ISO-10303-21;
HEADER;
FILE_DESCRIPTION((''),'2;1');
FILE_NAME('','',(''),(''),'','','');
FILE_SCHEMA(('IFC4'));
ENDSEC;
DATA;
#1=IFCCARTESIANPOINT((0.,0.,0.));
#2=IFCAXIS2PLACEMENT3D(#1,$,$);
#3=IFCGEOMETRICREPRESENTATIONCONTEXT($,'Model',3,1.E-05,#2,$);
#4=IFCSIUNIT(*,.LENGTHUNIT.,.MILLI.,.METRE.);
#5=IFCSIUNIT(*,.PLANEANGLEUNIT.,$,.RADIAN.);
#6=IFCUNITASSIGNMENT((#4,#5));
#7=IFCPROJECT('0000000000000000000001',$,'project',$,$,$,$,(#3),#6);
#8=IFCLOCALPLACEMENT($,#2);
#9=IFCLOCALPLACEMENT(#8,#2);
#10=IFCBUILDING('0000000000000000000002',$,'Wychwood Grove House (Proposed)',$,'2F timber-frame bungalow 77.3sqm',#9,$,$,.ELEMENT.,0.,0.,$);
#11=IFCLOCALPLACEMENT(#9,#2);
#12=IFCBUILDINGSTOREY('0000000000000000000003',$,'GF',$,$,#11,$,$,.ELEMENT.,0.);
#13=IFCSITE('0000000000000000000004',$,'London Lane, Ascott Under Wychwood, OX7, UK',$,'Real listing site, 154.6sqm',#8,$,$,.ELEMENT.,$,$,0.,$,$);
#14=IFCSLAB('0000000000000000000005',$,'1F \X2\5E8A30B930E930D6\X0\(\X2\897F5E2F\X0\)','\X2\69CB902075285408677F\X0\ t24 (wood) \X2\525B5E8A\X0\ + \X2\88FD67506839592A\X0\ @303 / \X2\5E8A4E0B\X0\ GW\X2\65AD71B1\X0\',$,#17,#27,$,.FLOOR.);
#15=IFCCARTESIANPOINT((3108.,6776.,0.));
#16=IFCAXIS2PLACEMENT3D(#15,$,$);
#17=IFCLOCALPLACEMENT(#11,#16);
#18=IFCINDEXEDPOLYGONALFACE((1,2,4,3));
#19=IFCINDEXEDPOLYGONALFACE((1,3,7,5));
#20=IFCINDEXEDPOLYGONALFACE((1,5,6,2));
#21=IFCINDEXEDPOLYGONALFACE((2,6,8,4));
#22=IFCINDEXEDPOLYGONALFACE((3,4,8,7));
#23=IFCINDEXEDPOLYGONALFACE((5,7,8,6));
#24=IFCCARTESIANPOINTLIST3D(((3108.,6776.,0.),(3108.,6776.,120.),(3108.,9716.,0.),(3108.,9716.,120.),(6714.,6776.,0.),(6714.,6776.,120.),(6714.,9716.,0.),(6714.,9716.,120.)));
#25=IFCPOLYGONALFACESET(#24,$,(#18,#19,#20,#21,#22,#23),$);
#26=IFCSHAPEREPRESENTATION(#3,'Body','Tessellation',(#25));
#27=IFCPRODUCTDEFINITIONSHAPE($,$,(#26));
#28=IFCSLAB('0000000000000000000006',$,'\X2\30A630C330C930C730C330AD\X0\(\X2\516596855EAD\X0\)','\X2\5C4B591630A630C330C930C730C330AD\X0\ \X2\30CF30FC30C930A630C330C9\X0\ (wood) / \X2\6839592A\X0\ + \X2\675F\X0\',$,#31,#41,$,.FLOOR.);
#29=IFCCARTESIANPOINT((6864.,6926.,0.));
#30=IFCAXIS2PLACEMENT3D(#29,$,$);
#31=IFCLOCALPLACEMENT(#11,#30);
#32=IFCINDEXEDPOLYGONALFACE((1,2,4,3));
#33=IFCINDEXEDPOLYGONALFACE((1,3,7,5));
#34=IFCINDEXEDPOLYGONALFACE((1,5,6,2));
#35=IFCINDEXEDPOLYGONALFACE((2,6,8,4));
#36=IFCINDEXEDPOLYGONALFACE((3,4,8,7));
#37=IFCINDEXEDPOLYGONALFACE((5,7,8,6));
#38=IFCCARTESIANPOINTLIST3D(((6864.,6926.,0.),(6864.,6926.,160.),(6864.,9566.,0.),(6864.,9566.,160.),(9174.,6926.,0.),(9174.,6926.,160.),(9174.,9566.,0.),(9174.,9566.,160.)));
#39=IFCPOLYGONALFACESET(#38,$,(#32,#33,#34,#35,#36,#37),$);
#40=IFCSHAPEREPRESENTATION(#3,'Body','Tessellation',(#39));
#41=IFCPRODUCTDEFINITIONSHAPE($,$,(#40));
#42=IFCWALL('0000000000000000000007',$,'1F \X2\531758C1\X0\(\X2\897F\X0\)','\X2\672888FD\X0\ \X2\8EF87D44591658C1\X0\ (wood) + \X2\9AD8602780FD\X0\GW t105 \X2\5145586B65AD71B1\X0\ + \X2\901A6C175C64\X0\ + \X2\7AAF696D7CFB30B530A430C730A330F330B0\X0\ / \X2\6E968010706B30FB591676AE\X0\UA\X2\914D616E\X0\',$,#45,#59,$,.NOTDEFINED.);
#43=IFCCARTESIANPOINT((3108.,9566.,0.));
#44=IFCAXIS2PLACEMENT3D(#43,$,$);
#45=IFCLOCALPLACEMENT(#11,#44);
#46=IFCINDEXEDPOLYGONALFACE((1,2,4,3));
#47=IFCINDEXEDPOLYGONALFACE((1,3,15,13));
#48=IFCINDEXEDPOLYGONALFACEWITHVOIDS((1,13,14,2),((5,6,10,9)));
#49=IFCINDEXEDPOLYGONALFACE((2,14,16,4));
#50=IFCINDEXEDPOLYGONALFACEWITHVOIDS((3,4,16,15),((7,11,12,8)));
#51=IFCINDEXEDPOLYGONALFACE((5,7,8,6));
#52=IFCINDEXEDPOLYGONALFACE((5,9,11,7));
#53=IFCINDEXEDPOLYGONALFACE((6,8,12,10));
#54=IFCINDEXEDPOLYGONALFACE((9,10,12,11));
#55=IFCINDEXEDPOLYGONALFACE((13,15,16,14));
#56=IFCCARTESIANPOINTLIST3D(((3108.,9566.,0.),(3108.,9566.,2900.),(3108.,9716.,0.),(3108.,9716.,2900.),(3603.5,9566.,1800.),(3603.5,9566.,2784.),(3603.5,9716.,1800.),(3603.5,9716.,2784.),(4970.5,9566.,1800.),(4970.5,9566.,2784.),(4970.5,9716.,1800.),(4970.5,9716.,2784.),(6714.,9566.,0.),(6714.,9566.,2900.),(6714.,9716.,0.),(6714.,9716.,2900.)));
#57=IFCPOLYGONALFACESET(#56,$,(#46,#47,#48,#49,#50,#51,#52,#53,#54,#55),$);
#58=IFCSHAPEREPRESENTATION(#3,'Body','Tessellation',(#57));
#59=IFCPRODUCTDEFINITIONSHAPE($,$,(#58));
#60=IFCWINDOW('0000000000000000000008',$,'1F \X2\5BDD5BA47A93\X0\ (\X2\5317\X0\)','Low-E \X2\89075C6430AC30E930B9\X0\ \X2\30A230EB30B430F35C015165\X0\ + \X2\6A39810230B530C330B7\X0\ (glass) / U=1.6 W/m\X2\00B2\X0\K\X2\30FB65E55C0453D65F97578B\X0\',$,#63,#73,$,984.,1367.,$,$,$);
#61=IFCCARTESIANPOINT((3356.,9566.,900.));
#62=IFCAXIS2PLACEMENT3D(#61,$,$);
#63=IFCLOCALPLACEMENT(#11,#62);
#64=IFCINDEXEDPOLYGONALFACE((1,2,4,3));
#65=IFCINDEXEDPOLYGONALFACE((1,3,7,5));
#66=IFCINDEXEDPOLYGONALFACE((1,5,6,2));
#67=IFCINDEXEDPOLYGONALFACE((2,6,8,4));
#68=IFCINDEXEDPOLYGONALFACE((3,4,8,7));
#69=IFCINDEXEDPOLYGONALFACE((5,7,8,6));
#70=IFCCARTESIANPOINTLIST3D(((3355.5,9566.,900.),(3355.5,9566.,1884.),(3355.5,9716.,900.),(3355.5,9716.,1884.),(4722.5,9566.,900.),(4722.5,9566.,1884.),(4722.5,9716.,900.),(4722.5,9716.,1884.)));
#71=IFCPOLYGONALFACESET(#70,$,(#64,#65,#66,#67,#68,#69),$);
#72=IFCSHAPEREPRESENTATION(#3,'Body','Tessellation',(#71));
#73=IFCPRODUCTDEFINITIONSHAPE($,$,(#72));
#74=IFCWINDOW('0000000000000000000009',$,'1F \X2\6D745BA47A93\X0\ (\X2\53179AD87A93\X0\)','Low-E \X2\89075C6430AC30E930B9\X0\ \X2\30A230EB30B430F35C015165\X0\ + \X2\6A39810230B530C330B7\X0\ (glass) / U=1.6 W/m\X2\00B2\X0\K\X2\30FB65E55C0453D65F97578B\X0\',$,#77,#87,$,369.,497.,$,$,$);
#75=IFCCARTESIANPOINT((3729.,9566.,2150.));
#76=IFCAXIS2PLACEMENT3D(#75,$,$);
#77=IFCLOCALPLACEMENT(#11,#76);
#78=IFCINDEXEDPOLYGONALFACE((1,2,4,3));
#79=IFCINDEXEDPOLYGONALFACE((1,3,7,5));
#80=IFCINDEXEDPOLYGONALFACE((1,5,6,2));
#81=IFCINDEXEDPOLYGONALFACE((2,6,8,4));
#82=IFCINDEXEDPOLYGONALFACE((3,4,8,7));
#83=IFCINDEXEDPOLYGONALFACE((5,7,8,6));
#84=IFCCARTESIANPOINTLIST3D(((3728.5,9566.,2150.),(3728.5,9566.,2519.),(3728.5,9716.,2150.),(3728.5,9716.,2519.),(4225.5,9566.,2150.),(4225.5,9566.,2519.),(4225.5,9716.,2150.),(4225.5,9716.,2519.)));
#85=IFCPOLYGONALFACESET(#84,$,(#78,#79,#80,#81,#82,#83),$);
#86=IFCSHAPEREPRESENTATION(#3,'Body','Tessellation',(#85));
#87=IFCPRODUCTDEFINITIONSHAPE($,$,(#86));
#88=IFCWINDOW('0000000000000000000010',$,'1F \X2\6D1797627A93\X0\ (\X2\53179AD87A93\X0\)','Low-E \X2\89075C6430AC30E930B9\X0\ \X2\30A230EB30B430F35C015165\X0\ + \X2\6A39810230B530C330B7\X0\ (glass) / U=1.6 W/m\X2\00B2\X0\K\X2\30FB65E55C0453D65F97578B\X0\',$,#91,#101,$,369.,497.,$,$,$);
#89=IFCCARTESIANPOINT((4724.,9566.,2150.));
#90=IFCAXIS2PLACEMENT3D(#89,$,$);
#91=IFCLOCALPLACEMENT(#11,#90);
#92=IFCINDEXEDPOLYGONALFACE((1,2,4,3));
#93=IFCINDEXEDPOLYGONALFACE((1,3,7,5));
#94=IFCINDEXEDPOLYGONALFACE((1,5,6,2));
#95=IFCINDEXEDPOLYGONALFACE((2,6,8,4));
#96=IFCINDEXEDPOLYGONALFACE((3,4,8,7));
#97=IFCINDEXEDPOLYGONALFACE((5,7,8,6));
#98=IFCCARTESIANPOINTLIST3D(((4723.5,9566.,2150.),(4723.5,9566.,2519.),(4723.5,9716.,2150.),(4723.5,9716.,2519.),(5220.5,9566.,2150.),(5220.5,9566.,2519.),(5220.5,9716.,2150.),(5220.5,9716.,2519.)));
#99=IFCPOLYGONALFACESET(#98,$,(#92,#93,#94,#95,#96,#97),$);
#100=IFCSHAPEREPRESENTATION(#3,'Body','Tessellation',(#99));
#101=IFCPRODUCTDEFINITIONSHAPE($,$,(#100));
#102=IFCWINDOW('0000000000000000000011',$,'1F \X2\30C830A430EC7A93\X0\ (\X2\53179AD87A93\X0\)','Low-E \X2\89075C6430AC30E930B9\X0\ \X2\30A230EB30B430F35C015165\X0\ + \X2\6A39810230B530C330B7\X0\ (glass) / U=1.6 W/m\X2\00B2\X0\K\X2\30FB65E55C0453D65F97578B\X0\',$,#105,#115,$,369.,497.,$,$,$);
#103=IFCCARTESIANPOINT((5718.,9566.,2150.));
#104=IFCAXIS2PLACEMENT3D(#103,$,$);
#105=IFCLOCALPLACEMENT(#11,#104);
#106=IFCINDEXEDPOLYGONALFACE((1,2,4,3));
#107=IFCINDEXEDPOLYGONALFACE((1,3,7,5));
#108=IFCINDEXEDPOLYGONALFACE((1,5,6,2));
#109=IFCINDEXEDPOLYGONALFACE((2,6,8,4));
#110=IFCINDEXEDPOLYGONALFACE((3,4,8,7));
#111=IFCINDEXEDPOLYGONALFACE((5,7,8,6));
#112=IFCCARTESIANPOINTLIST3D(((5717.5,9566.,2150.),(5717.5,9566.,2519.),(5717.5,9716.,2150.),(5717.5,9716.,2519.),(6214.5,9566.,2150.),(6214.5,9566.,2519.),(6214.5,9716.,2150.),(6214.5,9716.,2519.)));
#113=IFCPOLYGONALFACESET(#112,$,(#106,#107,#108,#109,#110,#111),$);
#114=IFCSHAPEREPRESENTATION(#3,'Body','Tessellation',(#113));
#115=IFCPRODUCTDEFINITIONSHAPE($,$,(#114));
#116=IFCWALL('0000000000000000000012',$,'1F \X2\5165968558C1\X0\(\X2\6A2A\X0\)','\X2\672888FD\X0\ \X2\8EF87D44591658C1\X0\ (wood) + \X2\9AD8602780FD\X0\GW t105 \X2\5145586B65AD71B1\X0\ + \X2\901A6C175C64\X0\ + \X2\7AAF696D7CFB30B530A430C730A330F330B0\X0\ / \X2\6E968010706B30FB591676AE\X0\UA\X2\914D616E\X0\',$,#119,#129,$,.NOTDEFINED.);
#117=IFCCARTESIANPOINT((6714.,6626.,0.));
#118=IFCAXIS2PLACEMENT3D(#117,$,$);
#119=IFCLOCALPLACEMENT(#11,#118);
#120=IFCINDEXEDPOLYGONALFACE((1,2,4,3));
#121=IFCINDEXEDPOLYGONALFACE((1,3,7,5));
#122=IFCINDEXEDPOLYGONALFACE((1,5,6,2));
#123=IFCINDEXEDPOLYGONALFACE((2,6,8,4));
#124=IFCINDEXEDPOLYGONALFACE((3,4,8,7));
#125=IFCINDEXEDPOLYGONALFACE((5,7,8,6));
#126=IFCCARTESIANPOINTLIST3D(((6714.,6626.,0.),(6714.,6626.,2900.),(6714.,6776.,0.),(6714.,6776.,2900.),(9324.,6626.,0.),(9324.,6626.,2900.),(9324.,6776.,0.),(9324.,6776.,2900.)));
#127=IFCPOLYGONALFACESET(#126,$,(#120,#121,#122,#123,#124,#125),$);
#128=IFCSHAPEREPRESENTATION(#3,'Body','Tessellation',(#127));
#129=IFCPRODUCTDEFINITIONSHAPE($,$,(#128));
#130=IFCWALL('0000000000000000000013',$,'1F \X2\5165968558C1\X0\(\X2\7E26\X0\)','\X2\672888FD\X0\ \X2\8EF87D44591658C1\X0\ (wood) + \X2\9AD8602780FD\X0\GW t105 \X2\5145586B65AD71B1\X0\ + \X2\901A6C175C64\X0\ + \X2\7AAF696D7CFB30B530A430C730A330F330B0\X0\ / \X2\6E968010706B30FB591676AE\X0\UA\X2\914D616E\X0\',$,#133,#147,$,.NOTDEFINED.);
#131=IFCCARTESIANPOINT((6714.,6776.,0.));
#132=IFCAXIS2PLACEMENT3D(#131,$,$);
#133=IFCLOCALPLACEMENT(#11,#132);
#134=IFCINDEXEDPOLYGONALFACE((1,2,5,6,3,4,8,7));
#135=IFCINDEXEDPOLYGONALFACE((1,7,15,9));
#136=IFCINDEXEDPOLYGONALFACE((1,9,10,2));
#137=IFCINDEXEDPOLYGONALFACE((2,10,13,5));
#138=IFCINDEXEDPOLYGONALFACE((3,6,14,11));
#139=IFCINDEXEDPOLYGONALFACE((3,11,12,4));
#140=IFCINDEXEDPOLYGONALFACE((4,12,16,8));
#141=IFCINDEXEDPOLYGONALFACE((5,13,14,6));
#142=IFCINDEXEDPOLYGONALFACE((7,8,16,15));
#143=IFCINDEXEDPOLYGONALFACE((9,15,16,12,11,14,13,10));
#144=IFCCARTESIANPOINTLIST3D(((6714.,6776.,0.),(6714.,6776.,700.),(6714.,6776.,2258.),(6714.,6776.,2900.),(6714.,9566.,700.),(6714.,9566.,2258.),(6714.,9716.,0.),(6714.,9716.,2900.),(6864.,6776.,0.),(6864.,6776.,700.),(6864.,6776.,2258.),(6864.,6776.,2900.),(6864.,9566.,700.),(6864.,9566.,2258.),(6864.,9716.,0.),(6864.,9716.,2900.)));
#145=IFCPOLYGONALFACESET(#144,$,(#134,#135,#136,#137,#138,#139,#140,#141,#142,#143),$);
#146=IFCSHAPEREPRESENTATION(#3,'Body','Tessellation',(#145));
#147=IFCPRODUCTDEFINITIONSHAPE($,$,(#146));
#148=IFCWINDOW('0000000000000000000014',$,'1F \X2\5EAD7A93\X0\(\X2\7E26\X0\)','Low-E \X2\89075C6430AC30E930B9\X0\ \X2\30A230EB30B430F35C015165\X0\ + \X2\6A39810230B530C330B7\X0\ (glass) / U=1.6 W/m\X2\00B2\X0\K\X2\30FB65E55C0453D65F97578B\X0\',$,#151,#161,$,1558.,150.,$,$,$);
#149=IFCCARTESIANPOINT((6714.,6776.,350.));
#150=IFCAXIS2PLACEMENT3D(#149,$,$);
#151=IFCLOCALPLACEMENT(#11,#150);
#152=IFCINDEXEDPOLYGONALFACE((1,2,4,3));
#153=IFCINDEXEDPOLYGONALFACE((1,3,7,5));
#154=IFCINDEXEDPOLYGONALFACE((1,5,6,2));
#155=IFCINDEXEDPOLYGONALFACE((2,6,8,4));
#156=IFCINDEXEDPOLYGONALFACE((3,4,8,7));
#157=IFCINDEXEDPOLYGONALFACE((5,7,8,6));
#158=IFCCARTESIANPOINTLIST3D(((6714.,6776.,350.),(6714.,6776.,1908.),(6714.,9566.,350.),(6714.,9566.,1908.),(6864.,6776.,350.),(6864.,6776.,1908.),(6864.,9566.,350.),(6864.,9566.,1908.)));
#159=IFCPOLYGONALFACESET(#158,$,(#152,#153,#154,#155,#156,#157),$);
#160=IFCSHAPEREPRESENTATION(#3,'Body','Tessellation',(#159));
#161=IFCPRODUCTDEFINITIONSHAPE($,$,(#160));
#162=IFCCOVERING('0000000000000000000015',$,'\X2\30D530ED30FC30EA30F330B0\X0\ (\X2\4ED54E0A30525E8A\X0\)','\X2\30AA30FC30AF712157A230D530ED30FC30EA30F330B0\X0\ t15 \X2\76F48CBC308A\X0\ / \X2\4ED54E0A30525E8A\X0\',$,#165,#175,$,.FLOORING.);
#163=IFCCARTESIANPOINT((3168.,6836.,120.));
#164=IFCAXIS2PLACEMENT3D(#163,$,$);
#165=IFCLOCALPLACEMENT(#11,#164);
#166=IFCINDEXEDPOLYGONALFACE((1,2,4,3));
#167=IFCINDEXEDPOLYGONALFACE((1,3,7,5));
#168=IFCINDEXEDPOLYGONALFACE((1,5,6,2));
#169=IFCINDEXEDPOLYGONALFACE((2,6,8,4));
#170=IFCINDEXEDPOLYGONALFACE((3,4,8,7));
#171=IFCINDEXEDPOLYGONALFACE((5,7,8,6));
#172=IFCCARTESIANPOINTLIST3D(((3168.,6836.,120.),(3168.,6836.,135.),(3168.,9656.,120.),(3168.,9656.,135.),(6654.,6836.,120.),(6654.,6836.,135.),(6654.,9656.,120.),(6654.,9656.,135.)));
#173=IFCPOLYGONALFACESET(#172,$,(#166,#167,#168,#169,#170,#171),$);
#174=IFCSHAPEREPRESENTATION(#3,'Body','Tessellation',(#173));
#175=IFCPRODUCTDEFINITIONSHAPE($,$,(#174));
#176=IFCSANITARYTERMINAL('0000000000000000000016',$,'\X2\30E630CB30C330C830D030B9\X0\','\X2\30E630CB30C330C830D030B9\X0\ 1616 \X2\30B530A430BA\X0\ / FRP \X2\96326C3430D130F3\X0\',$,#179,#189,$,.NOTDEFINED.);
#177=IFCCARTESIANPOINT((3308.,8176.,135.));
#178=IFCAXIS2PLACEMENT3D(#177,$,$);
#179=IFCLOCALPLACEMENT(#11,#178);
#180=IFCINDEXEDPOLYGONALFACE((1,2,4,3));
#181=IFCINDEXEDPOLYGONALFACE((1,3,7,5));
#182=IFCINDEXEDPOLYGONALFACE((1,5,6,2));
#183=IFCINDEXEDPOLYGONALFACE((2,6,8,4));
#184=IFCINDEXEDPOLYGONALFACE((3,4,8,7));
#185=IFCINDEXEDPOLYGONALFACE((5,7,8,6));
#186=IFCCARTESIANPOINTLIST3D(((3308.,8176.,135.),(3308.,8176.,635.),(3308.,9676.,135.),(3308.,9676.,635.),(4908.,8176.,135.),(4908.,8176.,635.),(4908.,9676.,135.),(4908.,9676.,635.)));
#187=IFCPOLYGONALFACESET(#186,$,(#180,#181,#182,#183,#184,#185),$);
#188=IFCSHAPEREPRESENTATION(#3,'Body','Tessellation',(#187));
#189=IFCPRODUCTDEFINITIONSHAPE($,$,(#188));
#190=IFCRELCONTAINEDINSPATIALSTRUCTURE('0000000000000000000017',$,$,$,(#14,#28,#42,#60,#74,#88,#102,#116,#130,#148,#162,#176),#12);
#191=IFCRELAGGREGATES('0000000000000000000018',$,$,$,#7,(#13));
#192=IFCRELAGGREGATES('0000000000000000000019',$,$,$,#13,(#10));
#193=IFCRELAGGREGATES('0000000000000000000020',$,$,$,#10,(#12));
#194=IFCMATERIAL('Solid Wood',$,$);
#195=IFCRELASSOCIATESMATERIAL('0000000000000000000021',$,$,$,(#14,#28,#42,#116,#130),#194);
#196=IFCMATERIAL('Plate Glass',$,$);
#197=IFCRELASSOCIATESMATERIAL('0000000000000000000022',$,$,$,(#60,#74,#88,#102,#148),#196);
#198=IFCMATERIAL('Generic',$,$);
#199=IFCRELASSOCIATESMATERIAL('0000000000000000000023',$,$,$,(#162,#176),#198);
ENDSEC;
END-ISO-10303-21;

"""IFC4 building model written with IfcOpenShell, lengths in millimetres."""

from ifc_helpers import new_model, si_unit, frame, frame_2d, origin, place, context, project, spatial, rectangle, extrude, material, element, fill, save


model = new_model("IFC4")

# Units and contexts
model_context = context("Model", 3, precision=1e-05, world=origin())
ifc_project = project(units=[si_unit("LENGTHUNIT", "METRE", prefix="MILLI"), si_unit("PLANEANGLEUNIT", "RADIAN")], contexts=[model_context])

# Site, building, storey
site_placement = place(None, origin())
site = spatial("IfcSite", under=ifc_project, at=site_placement, Name="London Lane, Ascott Under Wychwood, OX7, UK", ObjectType="Real listing site, 154.6sqm", CompositionType="ELEMENT", RefElevation=0.0)
building_placement = place(site_placement, origin())
building = spatial("IfcBuilding", under=site, at=building_placement, Name="Wychwood Grove House (Proposed)", ObjectType="2F timber-frame bungalow 77.3sqm", CompositionType="ELEMENT", ElevationOfRefHeight=0.0, ElevationOfTerrain=0.0)
storey_placement = place(building_placement, origin())
storey = spatial("IfcBuildingStorey", under=building, at=storey_placement, Name="GF", CompositionType="ELEMENT", Elevation=0.0)

# Slabs
ifc_material_1 = material(Name="Solid Wood")
slab_1_placement = place(storey_placement, frame((3108.0, 6776.0, 0.0)))
element("IfcSlab", 1, at=slab_1_placement, inside=storey, material=ifc_material_1, Name="1F 床スラブ(西帯)", Description="構造用合板 t24 (wood) 剛床 + 製材根太 @303 / 床下 GW断熱", PredefinedType="FLOOR", context=model_context, shape_type="SweptSolid", body=[
    extrude(rectangle(XDim=3606.0, YDim=2940.0, at=frame_2d((1803.0, 1470.0))), frame((3108.0, 6776.0, 0.0)), (0.0, 0.0, 1.0), 120.0),
])
slab_2_placement = place(storey_placement, frame((6864.0, 6926.0, 0.0)))
element("IfcSlab", 2, at=slab_2_placement, inside=storey, material=ifc_material_1, Name="ウッドデッキ(入隅庭)", Description="屋外ウッドデッキ ハードウッド (wood) / 根太 + 束", PredefinedType="FLOOR", context=model_context, shape_type="SweptSolid", body=[
    extrude(rectangle(XDim=2310.0, YDim=2640.0, at=frame_2d((1155.0, 1320.0))), frame((6864.0, 6926.0, 0.0)), (0.0, 0.0, 1.0), 160.0),
])

# Wall, openings, windows
wall_1_placement = place(storey_placement, frame((3108.0, 9566.0, 0.0)))
wall_1 = element("IfcWall", 3, at=wall_1_placement, inside=storey, material=ifc_material_1, Name="1F 北壁(西)", Description="木製 軸組外壁 (wood) + 高性能GW t105 充填断熱 + 通気層 + 窯業系サイディング / 準耐火・外皮UA配慮", PredefinedType="NOTDEFINED", context=model_context, shape_type="SweptSolid", body=[
    extrude(rectangle(XDim=3606.0, YDim=150.0, at=frame_2d((1803.0, 75.0))), frame((3108.0, 9566.0, 0.0)), (0.0, 0.0, 1.0), 2900.0),
])
opening_1_placement = place(storey_placement, frame((3356.0, 9566.0, 900.0)))
opening_1 = element("IfcOpeningElement", 4, at=opening_1_placement, cuts=wall_1, PredefinedType="NOTDEFINED", context=model_context, shape_type="SweptSolid", body=[
    extrude(rectangle(XDim=1367.0, YDim=150.0, at=frame_2d((683.0, 75.0))), frame((3356.0, 9566.0, 900.0)), (0.0, 0.0, 1.0), 984.0),
])
opening_2_placement = place(storey_placement, frame((3729.0, 9566.0, 2150.0)))
opening_2 = element("IfcOpeningElement", 5, at=opening_2_placement, cuts=wall_1, PredefinedType="NOTDEFINED", context=model_context, shape_type="SweptSolid", body=[
    extrude(rectangle(XDim=497.0, YDim=150.0, at=frame_2d((248.0, 75.0))), frame((3729.0, 9566.0, 2150.0)), (0.0, 0.0, 1.0), 369.0),
])
opening_3_placement = place(storey_placement, frame((4724.0, 9566.0, 2150.0)))
opening_3 = element("IfcOpeningElement", 6, at=opening_3_placement, cuts=wall_1, PredefinedType="NOTDEFINED", context=model_context, shape_type="SweptSolid", body=[
    extrude(rectangle(XDim=497.0, YDim=150.0, at=frame_2d((248.0, 75.0))), frame((4724.0, 9566.0, 2150.0)), (0.0, 0.0, 1.0), 369.0),
])
opening_4_placement = place(storey_placement, frame((5718.0, 9566.0, 2150.0)))
opening_4 = element("IfcOpeningElement", 7, at=opening_4_placement, cuts=wall_1, PredefinedType="NOTDEFINED", context=model_context, shape_type="SweptSolid", body=[
    extrude(rectangle(XDim=497.0, YDim=150.0, at=frame_2d((248.0, 75.0))), frame((5718.0, 9566.0, 2150.0)), (0.0, 0.0, 1.0), 369.0),
])
ifc_material_2 = material(Name="Plate Glass")
window_1_placement = place(storey_placement, frame((3356.0, 9566.0, 900.0)))
window_1 = element("IfcWindow", 8, at=window_1_placement, inside=storey, material=ifc_material_2, Name="1F 寝室窓 (北)", Description="Low-E 複層ガラス アルゴン封入 + 樹脂サッシ (glass) / U=1.6 W/m²K・日射取得型", OverallHeight=984.0, OverallWidth=1367.0, context=model_context, shape_type="SweptSolid", body=[
    extrude(rectangle(XDim=1367.0, YDim=150.0, at=frame_2d((683.0, 75.0))), frame((3356.0, 9566.0, 900.0)), (0.0, 0.0, 1.0), 984.0),
])
fill(opening_1, window_1)
window_2_placement = place(storey_placement, frame((3729.0, 9566.0, 2150.0)))
window_2 = element("IfcWindow", 9, at=window_2_placement, inside=storey, material=ifc_material_2, Name="1F 浴室窓 (北高窓)", Description="Low-E 複層ガラス アルゴン封入 + 樹脂サッシ (glass) / U=1.6 W/m²K・日射取得型", OverallHeight=369.0, OverallWidth=497.0, context=model_context, shape_type="SweptSolid", body=[
    extrude(rectangle(XDim=497.0, YDim=150.0, at=frame_2d((248.0, 75.0))), frame((3729.0, 9566.0, 2150.0)), (0.0, 0.0, 1.0), 369.0),
])
fill(opening_2, window_2)
window_3_placement = place(storey_placement, frame((4724.0, 9566.0, 2150.0)))
window_3 = element("IfcWindow", 10, at=window_3_placement, inside=storey, material=ifc_material_2, Name="1F 洗面窓 (北高窓)", Description="Low-E 複層ガラス アルゴン封入 + 樹脂サッシ (glass) / U=1.6 W/m²K・日射取得型", OverallHeight=369.0, OverallWidth=497.0, context=model_context, shape_type="SweptSolid", body=[
    extrude(rectangle(XDim=497.0, YDim=150.0, at=frame_2d((248.0, 75.0))), frame((4724.0, 9566.0, 2150.0)), (0.0, 0.0, 1.0), 369.0),
])
fill(opening_3, window_3)
window_4_placement = place(storey_placement, frame((5718.0, 9566.0, 2150.0)))
window_4 = element("IfcWindow", 11, at=window_4_placement, inside=storey, material=ifc_material_2, Name="1F トイレ窓 (北高窓)", Description="Low-E 複層ガラス アルゴン封入 + 樹脂サッシ (glass) / U=1.6 W/m²K・日射取得型", OverallHeight=369.0, OverallWidth=497.0, context=model_context, shape_type="SweptSolid", body=[
    extrude(rectangle(XDim=497.0, YDim=150.0, at=frame_2d((248.0, 75.0))), frame((5718.0, 9566.0, 2150.0)), (0.0, 0.0, 1.0), 369.0),
])
fill(opening_4, window_4)

# Wall
wall_2_placement = place(storey_placement, frame((6714.0, 6626.0, 0.0)))
element("IfcWall", 12, at=wall_2_placement, inside=storey, material=ifc_material_1, Name="1F 入隅壁(横)", Description="木製 軸組外壁 (wood) + 高性能GW t105 充填断熱 + 通気層 + 窯業系サイディング / 準耐火・外皮UA配慮", PredefinedType="NOTDEFINED", context=model_context, shape_type="SweptSolid", body=[
    extrude(rectangle(XDim=2610.0, YDim=150.0, at=frame_2d((1305.0, 75.0))), frame((6714.0, 6626.0, 0.0)), (0.0, 0.0, 1.0), 2900.0),
])

# Wall, opening, window
wall_3_placement = place(storey_placement, frame((6714.0, 6776.0, 0.0)))
wall_3 = element("IfcWall", 13, at=wall_3_placement, inside=storey, material=ifc_material_1, Name="1F 入隅壁(縦)", Description="木製 軸組外壁 (wood) + 高性能GW t105 充填断熱 + 通気層 + 窯業系サイディング / 準耐火・外皮UA配慮", PredefinedType="NOTDEFINED", context=model_context, shape_type="SweptSolid", body=[
    extrude(rectangle(XDim=150.0, YDim=2940.0, at=frame_2d((75.0, 1470.0))), frame((6714.0, 6776.0, 0.0)), (0.0, 0.0, 1.0), 2900.0),
])
opening_5_placement = place(storey_placement, frame((6714.0, 6776.0, 350.0)))
opening_5 = element("IfcOpeningElement", 14, at=opening_5_placement, cuts=wall_3, PredefinedType="NOTDEFINED", context=model_context, shape_type="SweptSolid", body=[
    extrude(rectangle(XDim=150.0, YDim=2790.0, at=frame_2d((75.0, 1395.0))), frame((6714.0, 6776.0, 350.0)), (0.0, 0.0, 1.0), 1558.0),
])
window_5_placement = place(storey_placement, frame((6714.0, 6776.0, 350.0)))
window_5 = element("IfcWindow", 15, at=window_5_placement, inside=storey, material=ifc_material_2, Name="1F 庭窓(縦)", Description="Low-E 複層ガラス アルゴン封入 + 樹脂サッシ (glass) / U=1.6 W/m²K・日射取得型", OverallHeight=1558.0, OverallWidth=150.0, context=model_context, shape_type="SweptSolid", body=[
    extrude(rectangle(XDim=150.0, YDim=2790.0, at=frame_2d((75.0, 1395.0))), frame((6714.0, 6776.0, 350.0)), (0.0, 0.0, 1.0), 1558.0),
])
fill(opening_5, window_5)

# Covering
ifc_material_3 = material(Name="Generic")
covering_placement = place(storey_placement, frame((3168.0, 6836.0, 120.0)))
element("IfcCovering", 16, at=covering_placement, inside=storey, material=ifc_material_3, Name="フローリング (仕上げ床)", Description="オーク無垢フローリング t15 直貼り / 仕上げ床", PredefinedType="FLOORING", context=model_context, shape_type="SweptSolid", body=[
    extrude(rectangle(XDim=3486.0, YDim=2820.0, at=frame_2d((1743.0, 1410.0))), frame((3168.0, 6836.0, 120.0)), (0.0, 0.0, 1.0), 15.0),
])

# Sanitary terminal
sanitary_terminal_1_placement = place(storey_placement, frame((3308.0, 8176.0, 135.0)))
element("IfcSanitaryTerminal", 17, at=sanitary_terminal_1_placement, inside=storey, material=ifc_material_3, Name="ユニットバス", Description="ユニットバス 1616 サイズ / FRP 防水パン", PredefinedType="NOTDEFINED", context=model_context, shape_type="SweptSolid", body=[
    extrude(rectangle(XDim=1600.0, YDim=1500.0, at=frame_2d((800.0, 750.0))), frame((3308.0, 8176.0, 135.0)), (0.0, 0.0, 1.0), 500.0),
])

save(model, "model.ifc")
